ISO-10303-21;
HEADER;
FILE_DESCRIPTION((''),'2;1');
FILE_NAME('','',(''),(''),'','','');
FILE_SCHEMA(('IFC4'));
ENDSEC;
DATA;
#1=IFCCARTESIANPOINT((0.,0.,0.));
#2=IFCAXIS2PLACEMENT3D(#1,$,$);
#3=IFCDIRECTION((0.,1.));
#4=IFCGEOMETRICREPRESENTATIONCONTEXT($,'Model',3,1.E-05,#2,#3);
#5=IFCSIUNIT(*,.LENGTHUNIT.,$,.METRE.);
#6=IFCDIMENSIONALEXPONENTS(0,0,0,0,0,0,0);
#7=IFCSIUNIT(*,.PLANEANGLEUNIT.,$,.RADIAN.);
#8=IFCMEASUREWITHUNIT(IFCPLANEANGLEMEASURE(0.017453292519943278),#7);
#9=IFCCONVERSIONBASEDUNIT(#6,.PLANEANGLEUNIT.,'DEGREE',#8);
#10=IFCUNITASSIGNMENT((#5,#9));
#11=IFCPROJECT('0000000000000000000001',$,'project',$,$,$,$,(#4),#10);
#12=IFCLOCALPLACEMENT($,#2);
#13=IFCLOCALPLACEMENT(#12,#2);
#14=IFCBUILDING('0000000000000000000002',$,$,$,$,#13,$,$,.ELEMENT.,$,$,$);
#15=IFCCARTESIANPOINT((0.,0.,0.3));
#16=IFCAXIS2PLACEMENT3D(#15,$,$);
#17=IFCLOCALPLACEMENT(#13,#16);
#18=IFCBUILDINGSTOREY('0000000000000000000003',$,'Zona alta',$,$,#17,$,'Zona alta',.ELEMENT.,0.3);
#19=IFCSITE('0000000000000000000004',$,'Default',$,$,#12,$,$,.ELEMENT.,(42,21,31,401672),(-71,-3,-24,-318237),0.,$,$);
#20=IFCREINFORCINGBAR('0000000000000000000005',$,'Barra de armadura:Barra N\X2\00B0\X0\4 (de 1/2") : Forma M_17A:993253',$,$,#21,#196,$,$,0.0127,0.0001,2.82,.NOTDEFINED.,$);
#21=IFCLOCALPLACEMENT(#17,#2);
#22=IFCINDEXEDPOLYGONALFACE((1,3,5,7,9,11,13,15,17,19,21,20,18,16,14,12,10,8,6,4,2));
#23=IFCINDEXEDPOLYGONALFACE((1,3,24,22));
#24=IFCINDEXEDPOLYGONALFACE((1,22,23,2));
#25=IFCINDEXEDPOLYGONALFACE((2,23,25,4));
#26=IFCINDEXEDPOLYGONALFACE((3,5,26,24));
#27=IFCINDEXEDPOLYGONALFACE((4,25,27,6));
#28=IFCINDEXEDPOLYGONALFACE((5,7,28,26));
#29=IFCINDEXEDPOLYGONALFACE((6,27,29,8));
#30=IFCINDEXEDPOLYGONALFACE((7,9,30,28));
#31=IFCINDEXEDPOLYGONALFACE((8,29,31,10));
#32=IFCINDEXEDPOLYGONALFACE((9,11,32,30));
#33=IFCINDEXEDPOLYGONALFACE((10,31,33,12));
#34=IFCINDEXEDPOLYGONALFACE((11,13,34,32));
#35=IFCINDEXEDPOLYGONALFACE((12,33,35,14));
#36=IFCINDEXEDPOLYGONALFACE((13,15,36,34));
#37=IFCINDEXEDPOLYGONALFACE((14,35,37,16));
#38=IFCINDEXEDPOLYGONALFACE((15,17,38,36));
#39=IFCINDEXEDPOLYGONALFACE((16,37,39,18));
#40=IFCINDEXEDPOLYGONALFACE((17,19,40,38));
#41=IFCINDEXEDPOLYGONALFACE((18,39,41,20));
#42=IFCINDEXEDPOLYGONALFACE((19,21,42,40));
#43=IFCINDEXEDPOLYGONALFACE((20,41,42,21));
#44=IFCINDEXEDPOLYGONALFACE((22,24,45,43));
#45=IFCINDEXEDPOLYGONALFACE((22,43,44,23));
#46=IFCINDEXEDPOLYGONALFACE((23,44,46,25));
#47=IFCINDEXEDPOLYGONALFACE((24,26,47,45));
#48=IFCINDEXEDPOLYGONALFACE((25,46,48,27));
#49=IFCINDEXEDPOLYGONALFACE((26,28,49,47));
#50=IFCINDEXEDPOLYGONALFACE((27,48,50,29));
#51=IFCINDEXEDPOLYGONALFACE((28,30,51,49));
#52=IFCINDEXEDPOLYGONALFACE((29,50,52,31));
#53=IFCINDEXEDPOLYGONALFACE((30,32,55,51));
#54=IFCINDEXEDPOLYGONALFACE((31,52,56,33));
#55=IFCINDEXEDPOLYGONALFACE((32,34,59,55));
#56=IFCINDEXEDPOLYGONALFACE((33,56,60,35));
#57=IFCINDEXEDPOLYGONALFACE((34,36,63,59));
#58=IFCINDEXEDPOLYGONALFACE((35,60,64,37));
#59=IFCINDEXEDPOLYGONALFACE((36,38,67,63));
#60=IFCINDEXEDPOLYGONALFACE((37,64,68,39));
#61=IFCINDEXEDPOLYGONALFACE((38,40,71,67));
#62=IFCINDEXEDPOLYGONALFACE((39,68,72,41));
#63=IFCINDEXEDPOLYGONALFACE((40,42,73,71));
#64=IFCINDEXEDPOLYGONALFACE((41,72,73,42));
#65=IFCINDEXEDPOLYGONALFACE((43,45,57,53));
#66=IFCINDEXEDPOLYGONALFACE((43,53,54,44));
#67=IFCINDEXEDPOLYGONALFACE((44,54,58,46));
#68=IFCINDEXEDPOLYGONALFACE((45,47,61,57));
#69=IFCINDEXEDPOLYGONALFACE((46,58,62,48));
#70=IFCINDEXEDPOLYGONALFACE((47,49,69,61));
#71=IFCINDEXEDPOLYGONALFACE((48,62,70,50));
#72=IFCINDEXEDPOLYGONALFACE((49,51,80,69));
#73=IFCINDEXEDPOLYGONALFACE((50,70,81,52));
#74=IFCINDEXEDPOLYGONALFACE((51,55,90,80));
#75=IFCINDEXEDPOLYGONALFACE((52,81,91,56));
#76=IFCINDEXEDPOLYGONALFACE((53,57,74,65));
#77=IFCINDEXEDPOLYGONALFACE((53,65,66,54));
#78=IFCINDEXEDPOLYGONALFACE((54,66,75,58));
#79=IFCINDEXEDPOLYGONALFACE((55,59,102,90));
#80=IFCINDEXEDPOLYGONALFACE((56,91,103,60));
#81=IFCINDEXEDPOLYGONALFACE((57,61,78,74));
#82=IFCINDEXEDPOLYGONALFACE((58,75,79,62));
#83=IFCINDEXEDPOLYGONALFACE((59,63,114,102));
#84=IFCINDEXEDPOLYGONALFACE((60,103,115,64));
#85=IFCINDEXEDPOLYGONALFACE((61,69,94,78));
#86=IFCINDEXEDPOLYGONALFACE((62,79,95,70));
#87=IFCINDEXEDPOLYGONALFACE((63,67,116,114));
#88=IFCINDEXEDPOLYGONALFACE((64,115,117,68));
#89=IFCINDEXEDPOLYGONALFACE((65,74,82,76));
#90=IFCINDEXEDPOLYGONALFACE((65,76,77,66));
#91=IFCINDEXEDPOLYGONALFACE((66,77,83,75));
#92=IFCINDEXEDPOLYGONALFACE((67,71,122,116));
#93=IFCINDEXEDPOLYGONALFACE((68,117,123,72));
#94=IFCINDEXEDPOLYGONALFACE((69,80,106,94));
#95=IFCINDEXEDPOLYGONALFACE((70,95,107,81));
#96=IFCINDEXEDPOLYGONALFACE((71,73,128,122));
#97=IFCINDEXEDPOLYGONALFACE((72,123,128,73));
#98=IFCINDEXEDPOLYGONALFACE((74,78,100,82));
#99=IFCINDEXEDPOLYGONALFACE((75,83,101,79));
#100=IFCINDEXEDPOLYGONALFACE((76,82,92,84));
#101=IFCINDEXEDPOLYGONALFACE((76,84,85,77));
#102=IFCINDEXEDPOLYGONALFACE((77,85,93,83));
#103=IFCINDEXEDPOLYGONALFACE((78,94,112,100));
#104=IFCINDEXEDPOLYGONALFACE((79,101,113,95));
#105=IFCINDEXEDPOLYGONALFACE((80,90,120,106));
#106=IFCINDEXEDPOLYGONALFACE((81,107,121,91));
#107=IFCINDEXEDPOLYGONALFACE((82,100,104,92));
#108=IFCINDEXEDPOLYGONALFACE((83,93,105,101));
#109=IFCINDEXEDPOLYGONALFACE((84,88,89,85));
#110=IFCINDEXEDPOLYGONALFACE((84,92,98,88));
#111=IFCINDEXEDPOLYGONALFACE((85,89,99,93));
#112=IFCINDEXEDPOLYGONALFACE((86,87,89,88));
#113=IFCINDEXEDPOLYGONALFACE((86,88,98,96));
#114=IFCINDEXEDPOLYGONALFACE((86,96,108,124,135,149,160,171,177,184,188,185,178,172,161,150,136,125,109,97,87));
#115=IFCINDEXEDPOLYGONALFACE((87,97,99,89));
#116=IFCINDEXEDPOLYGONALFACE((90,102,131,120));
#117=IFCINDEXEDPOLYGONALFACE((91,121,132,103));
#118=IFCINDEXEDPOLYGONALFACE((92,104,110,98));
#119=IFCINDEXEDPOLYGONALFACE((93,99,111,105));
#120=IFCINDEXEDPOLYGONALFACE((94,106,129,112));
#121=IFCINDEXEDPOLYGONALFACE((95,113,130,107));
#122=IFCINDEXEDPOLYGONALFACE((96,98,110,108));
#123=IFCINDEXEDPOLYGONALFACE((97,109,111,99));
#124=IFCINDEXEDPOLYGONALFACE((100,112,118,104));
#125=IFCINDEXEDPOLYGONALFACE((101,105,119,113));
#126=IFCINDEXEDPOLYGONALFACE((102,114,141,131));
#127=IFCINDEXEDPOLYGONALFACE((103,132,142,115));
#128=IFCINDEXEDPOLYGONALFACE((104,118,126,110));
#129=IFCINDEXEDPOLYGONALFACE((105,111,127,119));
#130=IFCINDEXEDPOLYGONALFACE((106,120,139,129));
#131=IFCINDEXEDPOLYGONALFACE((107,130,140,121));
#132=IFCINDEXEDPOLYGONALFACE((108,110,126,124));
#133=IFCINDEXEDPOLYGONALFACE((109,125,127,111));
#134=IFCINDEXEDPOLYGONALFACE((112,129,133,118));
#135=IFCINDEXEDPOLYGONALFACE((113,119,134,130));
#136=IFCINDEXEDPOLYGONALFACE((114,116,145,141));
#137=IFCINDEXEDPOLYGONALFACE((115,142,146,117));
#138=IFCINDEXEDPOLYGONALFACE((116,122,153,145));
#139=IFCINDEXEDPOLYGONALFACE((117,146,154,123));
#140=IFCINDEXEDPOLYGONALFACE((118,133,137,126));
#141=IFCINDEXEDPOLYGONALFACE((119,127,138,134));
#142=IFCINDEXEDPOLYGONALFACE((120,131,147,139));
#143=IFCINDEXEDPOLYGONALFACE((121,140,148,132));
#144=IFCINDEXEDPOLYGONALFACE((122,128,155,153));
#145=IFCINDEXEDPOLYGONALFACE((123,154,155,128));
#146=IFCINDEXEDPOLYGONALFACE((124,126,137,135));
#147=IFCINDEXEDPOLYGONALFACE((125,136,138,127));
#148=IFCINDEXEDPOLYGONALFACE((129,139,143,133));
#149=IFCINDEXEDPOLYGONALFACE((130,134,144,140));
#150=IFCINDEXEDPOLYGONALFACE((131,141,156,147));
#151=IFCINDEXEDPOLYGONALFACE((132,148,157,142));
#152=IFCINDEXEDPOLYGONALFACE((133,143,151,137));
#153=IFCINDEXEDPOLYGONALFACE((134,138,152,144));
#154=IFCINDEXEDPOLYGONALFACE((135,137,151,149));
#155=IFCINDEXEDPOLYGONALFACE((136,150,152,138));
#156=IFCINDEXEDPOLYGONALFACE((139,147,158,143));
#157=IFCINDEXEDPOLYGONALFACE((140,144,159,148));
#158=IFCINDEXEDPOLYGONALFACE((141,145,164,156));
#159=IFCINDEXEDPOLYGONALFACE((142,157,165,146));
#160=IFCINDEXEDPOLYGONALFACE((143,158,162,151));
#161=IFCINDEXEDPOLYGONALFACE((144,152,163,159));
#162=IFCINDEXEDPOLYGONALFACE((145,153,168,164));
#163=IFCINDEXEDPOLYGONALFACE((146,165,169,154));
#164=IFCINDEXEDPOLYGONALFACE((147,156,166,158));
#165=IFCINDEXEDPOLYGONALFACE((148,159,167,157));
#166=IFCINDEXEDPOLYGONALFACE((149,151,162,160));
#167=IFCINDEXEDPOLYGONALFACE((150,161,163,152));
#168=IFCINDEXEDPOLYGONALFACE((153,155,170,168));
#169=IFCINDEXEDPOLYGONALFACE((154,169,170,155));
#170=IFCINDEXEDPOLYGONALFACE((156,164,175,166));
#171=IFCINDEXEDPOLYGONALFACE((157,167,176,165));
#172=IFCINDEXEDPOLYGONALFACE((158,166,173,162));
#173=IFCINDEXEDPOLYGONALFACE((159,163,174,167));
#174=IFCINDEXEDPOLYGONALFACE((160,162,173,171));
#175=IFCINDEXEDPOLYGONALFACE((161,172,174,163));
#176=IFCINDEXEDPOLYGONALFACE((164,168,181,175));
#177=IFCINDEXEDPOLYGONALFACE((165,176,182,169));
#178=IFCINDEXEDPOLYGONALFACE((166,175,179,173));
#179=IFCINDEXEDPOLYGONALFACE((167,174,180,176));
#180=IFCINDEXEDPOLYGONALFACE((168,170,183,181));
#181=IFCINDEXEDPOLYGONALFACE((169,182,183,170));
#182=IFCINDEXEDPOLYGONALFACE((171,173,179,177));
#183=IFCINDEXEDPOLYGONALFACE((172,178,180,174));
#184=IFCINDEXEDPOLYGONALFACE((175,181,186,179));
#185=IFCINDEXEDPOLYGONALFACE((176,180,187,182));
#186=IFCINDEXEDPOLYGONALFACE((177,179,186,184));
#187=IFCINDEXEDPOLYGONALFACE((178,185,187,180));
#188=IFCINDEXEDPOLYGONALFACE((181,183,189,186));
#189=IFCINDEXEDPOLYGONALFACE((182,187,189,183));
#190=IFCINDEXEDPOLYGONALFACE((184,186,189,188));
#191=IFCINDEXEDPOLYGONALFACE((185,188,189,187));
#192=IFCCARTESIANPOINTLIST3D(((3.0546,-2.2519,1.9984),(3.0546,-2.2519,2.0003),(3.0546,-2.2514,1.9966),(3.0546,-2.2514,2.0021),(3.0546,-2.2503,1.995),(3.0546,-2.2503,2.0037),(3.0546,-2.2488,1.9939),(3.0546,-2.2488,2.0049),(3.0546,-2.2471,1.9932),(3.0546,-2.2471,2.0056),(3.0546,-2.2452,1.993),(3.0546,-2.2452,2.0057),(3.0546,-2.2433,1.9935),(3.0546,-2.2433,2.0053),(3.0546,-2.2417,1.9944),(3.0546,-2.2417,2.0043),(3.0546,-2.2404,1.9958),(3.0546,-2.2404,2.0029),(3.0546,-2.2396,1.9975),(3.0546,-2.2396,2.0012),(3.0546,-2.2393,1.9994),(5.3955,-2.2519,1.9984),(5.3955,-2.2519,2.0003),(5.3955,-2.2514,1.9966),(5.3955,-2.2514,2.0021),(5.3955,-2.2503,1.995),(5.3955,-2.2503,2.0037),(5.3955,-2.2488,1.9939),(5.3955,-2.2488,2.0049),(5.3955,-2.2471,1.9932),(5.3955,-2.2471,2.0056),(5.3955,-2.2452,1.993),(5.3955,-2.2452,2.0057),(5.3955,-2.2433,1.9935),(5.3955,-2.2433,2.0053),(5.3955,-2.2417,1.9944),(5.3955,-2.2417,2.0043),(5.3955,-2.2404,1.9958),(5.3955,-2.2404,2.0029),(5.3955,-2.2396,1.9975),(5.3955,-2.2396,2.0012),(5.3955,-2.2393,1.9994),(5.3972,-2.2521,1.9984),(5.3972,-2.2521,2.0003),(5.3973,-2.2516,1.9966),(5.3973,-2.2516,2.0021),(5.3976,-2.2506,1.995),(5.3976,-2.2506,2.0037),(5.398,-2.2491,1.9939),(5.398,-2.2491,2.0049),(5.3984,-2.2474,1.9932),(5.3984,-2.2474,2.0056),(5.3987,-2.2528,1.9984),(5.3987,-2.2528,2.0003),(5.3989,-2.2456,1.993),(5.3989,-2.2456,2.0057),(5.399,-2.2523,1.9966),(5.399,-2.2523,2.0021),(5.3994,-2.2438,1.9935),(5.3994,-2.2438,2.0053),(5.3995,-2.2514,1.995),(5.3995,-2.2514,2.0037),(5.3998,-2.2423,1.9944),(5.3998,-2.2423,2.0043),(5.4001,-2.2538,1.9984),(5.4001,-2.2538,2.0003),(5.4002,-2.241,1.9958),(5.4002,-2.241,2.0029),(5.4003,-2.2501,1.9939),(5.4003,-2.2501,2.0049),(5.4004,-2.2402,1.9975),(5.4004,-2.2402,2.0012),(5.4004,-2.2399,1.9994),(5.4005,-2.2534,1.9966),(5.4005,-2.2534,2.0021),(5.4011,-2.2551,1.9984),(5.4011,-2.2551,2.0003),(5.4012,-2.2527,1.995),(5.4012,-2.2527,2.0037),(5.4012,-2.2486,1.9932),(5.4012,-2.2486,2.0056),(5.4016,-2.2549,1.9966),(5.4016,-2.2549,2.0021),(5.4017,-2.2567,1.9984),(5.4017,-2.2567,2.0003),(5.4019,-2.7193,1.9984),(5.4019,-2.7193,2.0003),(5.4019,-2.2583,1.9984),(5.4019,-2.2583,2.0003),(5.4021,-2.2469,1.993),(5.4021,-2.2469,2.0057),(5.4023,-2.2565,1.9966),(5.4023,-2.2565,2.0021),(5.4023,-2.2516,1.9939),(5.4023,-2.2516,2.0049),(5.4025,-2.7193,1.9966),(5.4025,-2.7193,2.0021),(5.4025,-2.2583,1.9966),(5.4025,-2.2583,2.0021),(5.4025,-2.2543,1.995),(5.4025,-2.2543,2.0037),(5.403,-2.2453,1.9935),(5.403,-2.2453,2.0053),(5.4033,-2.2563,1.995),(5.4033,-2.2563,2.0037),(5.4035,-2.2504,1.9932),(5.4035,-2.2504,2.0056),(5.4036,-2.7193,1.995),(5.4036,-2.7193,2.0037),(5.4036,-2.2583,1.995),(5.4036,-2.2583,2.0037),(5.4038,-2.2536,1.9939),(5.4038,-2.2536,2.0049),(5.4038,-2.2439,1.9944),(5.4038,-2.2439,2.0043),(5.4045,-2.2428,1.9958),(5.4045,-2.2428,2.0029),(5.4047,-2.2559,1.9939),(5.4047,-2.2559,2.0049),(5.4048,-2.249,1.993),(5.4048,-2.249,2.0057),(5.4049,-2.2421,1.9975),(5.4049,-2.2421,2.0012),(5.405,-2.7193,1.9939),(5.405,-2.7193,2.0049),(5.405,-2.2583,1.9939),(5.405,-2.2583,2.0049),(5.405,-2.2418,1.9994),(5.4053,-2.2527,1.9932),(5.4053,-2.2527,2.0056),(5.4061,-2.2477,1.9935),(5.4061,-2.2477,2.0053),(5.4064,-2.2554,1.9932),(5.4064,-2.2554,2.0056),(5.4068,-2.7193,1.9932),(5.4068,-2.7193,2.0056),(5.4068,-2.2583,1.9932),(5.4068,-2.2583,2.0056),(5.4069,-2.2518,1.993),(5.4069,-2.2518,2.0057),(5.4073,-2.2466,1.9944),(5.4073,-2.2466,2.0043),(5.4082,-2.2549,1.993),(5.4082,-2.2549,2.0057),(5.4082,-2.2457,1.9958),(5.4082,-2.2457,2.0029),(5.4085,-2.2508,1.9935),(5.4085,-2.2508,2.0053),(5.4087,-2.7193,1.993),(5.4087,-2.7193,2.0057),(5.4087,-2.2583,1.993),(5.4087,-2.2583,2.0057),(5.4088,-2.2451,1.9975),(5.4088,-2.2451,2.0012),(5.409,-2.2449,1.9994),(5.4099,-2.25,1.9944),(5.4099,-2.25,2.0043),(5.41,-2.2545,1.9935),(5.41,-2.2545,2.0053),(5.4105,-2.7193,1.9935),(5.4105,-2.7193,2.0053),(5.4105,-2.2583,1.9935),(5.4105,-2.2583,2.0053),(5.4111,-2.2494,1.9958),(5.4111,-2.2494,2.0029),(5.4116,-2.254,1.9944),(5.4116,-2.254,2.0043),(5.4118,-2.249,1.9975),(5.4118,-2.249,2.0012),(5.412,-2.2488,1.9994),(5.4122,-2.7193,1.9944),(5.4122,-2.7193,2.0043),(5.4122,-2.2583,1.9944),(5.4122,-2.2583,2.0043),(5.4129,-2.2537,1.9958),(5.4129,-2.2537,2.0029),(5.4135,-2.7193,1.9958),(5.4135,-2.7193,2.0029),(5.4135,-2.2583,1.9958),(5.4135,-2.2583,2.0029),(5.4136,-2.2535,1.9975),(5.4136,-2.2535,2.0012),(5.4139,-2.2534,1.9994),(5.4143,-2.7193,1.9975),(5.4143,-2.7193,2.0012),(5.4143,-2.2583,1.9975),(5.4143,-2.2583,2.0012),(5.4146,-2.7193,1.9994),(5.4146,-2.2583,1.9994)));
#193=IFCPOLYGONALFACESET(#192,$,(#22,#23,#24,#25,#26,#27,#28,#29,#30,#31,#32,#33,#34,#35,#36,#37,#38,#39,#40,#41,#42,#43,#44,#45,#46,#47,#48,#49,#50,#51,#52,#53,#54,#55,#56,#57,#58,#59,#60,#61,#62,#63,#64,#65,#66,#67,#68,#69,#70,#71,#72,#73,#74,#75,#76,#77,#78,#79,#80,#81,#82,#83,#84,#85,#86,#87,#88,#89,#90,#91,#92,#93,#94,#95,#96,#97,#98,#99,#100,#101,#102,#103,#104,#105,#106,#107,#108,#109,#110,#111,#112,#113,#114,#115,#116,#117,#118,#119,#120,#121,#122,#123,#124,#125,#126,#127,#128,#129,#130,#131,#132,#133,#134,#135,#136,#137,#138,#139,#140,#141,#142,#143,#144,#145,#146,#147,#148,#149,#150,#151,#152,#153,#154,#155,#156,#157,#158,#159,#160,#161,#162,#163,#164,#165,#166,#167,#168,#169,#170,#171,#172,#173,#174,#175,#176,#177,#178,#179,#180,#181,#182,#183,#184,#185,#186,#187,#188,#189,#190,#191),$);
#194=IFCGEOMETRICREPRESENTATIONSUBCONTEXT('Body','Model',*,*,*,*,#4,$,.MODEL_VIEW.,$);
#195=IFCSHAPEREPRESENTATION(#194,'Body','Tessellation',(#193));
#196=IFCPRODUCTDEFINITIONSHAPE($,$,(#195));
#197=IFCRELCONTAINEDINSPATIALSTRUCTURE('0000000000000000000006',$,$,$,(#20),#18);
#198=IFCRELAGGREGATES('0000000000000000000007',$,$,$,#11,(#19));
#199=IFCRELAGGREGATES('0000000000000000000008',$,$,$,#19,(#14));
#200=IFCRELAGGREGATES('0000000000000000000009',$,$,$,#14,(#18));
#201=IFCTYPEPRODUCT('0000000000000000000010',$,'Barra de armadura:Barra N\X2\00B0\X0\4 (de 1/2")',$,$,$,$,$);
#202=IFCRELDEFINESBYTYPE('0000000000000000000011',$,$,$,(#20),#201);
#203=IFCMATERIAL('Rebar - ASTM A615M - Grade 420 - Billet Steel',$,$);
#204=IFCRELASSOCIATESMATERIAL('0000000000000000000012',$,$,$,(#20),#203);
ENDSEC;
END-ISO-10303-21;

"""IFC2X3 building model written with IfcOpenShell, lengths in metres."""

from ifc_helpers import new_model, entity, si_unit, converted_unit, direction, frame, origin, place, context, subcontext, project, spatial, material, type_object, element, save


model = new_model("IFC2X3")

# Units and contexts
model_context = context("Model", 3, precision=1e-05, world=origin(), true_north=direction((0.0, 1.0)))
body_context = subcontext(model_context, "Body", "Model", "MODEL_VIEW")
ifc_project = project(units=[si_unit("LENGTHUNIT", "METRE"), converted_unit("PLANEANGLEUNIT", "DEGREE", entity("IfcPlaneAngleMeasure", 0.017453292519943278), si_unit("PLANEANGLEUNIT", "RADIAN"), dimensions=[0, 0, 0, 0, 0, 0, 0])], contexts=[model_context])

# Site, building, storey
site_placement = place(None, origin())
site = spatial("IfcSite", under=ifc_project, at=site_placement, Name="Default", CompositionType="ELEMENT", RefLatitude=(42, 21, 31, 401672), RefLongitude=(-71, -3, -24, -318237), RefElevation=0.0)
building_placement = place(site_placement, origin())
building = spatial("IfcBuilding", under=site, at=building_placement, CompositionType="ELEMENT")
storey_placement = place(building_placement, frame((0.0, 0.0, 0.3)))
storey = spatial("IfcBuildingStorey", under=building, at=storey_placement, Name="Zona alta", LongName="Zona alta", CompositionType="ELEMENT", Elevation=0.3)

# Reinforcing bar
ifc_material_1 = material(Name="Rebar - ASTM A615M - Grade 420 - Billet Steel")
type_product_1 = type_object("IfcTypeProduct", Name="Barra de armadura:Barra N°4 (de 1/2\")")
reinforcing_bar_1_placement = place(storey_placement, origin())
element("IfcReinforcingBar", 1, at=reinforcing_bar_1_placement, inside=storey, type_object=type_product_1, material=ifc_material_1, Name="Barra de armadura:Barra N°4 (de 1/2\") : Forma M_17A:993253", BarLength=2.82, BarRole="NOTDEFINED", CrossSectionArea=0.0001, NominalDiameter=0.0127, context=body_context, shape_type="AdvancedSweptSolid", body=[
    entity("IfcSweptDiskSolid", entity("IfcCompositeCurve", [entity("IfcCompositeCurveSegment", "CONTINUOUS", True, entity("IfcPolyline", [entity("IfcCartesianPoint", [3.0546, -2.2456, 1.9994]), entity("IfcCartesianPoint", [5.3955, -2.2456, 1.9994])])), entity("IfcCompositeCurveSegment", "CONTINUOUS", True, entity("IfcTrimmedCurve", entity("IfcCircle", entity("IfcAxis2Placement3D", entity("IfcCartesianPoint", [5.3955, -2.2583, 1.9994]), entity("IfcDirection", [0.0, 0.0, -1.0]), entity("IfcDirection", [1.0, 0.0, 0.0])), 0.0127), [entity("IfcParameterValue", 270.0)], [entity("IfcParameterValue", 360.0)], True, "PARAMETER")), entity("IfcCompositeCurveSegment", "CONTINUOUS", True, entity("IfcPolyline", [entity("IfcCartesianPoint", [5.4082, -2.2583, 1.9994]), entity("IfcCartesianPoint", [5.4082, -2.7193, 1.9994])]))], False), 0.0063, None, 0.0, 92.0),
])

save(model, "model.ifc")
